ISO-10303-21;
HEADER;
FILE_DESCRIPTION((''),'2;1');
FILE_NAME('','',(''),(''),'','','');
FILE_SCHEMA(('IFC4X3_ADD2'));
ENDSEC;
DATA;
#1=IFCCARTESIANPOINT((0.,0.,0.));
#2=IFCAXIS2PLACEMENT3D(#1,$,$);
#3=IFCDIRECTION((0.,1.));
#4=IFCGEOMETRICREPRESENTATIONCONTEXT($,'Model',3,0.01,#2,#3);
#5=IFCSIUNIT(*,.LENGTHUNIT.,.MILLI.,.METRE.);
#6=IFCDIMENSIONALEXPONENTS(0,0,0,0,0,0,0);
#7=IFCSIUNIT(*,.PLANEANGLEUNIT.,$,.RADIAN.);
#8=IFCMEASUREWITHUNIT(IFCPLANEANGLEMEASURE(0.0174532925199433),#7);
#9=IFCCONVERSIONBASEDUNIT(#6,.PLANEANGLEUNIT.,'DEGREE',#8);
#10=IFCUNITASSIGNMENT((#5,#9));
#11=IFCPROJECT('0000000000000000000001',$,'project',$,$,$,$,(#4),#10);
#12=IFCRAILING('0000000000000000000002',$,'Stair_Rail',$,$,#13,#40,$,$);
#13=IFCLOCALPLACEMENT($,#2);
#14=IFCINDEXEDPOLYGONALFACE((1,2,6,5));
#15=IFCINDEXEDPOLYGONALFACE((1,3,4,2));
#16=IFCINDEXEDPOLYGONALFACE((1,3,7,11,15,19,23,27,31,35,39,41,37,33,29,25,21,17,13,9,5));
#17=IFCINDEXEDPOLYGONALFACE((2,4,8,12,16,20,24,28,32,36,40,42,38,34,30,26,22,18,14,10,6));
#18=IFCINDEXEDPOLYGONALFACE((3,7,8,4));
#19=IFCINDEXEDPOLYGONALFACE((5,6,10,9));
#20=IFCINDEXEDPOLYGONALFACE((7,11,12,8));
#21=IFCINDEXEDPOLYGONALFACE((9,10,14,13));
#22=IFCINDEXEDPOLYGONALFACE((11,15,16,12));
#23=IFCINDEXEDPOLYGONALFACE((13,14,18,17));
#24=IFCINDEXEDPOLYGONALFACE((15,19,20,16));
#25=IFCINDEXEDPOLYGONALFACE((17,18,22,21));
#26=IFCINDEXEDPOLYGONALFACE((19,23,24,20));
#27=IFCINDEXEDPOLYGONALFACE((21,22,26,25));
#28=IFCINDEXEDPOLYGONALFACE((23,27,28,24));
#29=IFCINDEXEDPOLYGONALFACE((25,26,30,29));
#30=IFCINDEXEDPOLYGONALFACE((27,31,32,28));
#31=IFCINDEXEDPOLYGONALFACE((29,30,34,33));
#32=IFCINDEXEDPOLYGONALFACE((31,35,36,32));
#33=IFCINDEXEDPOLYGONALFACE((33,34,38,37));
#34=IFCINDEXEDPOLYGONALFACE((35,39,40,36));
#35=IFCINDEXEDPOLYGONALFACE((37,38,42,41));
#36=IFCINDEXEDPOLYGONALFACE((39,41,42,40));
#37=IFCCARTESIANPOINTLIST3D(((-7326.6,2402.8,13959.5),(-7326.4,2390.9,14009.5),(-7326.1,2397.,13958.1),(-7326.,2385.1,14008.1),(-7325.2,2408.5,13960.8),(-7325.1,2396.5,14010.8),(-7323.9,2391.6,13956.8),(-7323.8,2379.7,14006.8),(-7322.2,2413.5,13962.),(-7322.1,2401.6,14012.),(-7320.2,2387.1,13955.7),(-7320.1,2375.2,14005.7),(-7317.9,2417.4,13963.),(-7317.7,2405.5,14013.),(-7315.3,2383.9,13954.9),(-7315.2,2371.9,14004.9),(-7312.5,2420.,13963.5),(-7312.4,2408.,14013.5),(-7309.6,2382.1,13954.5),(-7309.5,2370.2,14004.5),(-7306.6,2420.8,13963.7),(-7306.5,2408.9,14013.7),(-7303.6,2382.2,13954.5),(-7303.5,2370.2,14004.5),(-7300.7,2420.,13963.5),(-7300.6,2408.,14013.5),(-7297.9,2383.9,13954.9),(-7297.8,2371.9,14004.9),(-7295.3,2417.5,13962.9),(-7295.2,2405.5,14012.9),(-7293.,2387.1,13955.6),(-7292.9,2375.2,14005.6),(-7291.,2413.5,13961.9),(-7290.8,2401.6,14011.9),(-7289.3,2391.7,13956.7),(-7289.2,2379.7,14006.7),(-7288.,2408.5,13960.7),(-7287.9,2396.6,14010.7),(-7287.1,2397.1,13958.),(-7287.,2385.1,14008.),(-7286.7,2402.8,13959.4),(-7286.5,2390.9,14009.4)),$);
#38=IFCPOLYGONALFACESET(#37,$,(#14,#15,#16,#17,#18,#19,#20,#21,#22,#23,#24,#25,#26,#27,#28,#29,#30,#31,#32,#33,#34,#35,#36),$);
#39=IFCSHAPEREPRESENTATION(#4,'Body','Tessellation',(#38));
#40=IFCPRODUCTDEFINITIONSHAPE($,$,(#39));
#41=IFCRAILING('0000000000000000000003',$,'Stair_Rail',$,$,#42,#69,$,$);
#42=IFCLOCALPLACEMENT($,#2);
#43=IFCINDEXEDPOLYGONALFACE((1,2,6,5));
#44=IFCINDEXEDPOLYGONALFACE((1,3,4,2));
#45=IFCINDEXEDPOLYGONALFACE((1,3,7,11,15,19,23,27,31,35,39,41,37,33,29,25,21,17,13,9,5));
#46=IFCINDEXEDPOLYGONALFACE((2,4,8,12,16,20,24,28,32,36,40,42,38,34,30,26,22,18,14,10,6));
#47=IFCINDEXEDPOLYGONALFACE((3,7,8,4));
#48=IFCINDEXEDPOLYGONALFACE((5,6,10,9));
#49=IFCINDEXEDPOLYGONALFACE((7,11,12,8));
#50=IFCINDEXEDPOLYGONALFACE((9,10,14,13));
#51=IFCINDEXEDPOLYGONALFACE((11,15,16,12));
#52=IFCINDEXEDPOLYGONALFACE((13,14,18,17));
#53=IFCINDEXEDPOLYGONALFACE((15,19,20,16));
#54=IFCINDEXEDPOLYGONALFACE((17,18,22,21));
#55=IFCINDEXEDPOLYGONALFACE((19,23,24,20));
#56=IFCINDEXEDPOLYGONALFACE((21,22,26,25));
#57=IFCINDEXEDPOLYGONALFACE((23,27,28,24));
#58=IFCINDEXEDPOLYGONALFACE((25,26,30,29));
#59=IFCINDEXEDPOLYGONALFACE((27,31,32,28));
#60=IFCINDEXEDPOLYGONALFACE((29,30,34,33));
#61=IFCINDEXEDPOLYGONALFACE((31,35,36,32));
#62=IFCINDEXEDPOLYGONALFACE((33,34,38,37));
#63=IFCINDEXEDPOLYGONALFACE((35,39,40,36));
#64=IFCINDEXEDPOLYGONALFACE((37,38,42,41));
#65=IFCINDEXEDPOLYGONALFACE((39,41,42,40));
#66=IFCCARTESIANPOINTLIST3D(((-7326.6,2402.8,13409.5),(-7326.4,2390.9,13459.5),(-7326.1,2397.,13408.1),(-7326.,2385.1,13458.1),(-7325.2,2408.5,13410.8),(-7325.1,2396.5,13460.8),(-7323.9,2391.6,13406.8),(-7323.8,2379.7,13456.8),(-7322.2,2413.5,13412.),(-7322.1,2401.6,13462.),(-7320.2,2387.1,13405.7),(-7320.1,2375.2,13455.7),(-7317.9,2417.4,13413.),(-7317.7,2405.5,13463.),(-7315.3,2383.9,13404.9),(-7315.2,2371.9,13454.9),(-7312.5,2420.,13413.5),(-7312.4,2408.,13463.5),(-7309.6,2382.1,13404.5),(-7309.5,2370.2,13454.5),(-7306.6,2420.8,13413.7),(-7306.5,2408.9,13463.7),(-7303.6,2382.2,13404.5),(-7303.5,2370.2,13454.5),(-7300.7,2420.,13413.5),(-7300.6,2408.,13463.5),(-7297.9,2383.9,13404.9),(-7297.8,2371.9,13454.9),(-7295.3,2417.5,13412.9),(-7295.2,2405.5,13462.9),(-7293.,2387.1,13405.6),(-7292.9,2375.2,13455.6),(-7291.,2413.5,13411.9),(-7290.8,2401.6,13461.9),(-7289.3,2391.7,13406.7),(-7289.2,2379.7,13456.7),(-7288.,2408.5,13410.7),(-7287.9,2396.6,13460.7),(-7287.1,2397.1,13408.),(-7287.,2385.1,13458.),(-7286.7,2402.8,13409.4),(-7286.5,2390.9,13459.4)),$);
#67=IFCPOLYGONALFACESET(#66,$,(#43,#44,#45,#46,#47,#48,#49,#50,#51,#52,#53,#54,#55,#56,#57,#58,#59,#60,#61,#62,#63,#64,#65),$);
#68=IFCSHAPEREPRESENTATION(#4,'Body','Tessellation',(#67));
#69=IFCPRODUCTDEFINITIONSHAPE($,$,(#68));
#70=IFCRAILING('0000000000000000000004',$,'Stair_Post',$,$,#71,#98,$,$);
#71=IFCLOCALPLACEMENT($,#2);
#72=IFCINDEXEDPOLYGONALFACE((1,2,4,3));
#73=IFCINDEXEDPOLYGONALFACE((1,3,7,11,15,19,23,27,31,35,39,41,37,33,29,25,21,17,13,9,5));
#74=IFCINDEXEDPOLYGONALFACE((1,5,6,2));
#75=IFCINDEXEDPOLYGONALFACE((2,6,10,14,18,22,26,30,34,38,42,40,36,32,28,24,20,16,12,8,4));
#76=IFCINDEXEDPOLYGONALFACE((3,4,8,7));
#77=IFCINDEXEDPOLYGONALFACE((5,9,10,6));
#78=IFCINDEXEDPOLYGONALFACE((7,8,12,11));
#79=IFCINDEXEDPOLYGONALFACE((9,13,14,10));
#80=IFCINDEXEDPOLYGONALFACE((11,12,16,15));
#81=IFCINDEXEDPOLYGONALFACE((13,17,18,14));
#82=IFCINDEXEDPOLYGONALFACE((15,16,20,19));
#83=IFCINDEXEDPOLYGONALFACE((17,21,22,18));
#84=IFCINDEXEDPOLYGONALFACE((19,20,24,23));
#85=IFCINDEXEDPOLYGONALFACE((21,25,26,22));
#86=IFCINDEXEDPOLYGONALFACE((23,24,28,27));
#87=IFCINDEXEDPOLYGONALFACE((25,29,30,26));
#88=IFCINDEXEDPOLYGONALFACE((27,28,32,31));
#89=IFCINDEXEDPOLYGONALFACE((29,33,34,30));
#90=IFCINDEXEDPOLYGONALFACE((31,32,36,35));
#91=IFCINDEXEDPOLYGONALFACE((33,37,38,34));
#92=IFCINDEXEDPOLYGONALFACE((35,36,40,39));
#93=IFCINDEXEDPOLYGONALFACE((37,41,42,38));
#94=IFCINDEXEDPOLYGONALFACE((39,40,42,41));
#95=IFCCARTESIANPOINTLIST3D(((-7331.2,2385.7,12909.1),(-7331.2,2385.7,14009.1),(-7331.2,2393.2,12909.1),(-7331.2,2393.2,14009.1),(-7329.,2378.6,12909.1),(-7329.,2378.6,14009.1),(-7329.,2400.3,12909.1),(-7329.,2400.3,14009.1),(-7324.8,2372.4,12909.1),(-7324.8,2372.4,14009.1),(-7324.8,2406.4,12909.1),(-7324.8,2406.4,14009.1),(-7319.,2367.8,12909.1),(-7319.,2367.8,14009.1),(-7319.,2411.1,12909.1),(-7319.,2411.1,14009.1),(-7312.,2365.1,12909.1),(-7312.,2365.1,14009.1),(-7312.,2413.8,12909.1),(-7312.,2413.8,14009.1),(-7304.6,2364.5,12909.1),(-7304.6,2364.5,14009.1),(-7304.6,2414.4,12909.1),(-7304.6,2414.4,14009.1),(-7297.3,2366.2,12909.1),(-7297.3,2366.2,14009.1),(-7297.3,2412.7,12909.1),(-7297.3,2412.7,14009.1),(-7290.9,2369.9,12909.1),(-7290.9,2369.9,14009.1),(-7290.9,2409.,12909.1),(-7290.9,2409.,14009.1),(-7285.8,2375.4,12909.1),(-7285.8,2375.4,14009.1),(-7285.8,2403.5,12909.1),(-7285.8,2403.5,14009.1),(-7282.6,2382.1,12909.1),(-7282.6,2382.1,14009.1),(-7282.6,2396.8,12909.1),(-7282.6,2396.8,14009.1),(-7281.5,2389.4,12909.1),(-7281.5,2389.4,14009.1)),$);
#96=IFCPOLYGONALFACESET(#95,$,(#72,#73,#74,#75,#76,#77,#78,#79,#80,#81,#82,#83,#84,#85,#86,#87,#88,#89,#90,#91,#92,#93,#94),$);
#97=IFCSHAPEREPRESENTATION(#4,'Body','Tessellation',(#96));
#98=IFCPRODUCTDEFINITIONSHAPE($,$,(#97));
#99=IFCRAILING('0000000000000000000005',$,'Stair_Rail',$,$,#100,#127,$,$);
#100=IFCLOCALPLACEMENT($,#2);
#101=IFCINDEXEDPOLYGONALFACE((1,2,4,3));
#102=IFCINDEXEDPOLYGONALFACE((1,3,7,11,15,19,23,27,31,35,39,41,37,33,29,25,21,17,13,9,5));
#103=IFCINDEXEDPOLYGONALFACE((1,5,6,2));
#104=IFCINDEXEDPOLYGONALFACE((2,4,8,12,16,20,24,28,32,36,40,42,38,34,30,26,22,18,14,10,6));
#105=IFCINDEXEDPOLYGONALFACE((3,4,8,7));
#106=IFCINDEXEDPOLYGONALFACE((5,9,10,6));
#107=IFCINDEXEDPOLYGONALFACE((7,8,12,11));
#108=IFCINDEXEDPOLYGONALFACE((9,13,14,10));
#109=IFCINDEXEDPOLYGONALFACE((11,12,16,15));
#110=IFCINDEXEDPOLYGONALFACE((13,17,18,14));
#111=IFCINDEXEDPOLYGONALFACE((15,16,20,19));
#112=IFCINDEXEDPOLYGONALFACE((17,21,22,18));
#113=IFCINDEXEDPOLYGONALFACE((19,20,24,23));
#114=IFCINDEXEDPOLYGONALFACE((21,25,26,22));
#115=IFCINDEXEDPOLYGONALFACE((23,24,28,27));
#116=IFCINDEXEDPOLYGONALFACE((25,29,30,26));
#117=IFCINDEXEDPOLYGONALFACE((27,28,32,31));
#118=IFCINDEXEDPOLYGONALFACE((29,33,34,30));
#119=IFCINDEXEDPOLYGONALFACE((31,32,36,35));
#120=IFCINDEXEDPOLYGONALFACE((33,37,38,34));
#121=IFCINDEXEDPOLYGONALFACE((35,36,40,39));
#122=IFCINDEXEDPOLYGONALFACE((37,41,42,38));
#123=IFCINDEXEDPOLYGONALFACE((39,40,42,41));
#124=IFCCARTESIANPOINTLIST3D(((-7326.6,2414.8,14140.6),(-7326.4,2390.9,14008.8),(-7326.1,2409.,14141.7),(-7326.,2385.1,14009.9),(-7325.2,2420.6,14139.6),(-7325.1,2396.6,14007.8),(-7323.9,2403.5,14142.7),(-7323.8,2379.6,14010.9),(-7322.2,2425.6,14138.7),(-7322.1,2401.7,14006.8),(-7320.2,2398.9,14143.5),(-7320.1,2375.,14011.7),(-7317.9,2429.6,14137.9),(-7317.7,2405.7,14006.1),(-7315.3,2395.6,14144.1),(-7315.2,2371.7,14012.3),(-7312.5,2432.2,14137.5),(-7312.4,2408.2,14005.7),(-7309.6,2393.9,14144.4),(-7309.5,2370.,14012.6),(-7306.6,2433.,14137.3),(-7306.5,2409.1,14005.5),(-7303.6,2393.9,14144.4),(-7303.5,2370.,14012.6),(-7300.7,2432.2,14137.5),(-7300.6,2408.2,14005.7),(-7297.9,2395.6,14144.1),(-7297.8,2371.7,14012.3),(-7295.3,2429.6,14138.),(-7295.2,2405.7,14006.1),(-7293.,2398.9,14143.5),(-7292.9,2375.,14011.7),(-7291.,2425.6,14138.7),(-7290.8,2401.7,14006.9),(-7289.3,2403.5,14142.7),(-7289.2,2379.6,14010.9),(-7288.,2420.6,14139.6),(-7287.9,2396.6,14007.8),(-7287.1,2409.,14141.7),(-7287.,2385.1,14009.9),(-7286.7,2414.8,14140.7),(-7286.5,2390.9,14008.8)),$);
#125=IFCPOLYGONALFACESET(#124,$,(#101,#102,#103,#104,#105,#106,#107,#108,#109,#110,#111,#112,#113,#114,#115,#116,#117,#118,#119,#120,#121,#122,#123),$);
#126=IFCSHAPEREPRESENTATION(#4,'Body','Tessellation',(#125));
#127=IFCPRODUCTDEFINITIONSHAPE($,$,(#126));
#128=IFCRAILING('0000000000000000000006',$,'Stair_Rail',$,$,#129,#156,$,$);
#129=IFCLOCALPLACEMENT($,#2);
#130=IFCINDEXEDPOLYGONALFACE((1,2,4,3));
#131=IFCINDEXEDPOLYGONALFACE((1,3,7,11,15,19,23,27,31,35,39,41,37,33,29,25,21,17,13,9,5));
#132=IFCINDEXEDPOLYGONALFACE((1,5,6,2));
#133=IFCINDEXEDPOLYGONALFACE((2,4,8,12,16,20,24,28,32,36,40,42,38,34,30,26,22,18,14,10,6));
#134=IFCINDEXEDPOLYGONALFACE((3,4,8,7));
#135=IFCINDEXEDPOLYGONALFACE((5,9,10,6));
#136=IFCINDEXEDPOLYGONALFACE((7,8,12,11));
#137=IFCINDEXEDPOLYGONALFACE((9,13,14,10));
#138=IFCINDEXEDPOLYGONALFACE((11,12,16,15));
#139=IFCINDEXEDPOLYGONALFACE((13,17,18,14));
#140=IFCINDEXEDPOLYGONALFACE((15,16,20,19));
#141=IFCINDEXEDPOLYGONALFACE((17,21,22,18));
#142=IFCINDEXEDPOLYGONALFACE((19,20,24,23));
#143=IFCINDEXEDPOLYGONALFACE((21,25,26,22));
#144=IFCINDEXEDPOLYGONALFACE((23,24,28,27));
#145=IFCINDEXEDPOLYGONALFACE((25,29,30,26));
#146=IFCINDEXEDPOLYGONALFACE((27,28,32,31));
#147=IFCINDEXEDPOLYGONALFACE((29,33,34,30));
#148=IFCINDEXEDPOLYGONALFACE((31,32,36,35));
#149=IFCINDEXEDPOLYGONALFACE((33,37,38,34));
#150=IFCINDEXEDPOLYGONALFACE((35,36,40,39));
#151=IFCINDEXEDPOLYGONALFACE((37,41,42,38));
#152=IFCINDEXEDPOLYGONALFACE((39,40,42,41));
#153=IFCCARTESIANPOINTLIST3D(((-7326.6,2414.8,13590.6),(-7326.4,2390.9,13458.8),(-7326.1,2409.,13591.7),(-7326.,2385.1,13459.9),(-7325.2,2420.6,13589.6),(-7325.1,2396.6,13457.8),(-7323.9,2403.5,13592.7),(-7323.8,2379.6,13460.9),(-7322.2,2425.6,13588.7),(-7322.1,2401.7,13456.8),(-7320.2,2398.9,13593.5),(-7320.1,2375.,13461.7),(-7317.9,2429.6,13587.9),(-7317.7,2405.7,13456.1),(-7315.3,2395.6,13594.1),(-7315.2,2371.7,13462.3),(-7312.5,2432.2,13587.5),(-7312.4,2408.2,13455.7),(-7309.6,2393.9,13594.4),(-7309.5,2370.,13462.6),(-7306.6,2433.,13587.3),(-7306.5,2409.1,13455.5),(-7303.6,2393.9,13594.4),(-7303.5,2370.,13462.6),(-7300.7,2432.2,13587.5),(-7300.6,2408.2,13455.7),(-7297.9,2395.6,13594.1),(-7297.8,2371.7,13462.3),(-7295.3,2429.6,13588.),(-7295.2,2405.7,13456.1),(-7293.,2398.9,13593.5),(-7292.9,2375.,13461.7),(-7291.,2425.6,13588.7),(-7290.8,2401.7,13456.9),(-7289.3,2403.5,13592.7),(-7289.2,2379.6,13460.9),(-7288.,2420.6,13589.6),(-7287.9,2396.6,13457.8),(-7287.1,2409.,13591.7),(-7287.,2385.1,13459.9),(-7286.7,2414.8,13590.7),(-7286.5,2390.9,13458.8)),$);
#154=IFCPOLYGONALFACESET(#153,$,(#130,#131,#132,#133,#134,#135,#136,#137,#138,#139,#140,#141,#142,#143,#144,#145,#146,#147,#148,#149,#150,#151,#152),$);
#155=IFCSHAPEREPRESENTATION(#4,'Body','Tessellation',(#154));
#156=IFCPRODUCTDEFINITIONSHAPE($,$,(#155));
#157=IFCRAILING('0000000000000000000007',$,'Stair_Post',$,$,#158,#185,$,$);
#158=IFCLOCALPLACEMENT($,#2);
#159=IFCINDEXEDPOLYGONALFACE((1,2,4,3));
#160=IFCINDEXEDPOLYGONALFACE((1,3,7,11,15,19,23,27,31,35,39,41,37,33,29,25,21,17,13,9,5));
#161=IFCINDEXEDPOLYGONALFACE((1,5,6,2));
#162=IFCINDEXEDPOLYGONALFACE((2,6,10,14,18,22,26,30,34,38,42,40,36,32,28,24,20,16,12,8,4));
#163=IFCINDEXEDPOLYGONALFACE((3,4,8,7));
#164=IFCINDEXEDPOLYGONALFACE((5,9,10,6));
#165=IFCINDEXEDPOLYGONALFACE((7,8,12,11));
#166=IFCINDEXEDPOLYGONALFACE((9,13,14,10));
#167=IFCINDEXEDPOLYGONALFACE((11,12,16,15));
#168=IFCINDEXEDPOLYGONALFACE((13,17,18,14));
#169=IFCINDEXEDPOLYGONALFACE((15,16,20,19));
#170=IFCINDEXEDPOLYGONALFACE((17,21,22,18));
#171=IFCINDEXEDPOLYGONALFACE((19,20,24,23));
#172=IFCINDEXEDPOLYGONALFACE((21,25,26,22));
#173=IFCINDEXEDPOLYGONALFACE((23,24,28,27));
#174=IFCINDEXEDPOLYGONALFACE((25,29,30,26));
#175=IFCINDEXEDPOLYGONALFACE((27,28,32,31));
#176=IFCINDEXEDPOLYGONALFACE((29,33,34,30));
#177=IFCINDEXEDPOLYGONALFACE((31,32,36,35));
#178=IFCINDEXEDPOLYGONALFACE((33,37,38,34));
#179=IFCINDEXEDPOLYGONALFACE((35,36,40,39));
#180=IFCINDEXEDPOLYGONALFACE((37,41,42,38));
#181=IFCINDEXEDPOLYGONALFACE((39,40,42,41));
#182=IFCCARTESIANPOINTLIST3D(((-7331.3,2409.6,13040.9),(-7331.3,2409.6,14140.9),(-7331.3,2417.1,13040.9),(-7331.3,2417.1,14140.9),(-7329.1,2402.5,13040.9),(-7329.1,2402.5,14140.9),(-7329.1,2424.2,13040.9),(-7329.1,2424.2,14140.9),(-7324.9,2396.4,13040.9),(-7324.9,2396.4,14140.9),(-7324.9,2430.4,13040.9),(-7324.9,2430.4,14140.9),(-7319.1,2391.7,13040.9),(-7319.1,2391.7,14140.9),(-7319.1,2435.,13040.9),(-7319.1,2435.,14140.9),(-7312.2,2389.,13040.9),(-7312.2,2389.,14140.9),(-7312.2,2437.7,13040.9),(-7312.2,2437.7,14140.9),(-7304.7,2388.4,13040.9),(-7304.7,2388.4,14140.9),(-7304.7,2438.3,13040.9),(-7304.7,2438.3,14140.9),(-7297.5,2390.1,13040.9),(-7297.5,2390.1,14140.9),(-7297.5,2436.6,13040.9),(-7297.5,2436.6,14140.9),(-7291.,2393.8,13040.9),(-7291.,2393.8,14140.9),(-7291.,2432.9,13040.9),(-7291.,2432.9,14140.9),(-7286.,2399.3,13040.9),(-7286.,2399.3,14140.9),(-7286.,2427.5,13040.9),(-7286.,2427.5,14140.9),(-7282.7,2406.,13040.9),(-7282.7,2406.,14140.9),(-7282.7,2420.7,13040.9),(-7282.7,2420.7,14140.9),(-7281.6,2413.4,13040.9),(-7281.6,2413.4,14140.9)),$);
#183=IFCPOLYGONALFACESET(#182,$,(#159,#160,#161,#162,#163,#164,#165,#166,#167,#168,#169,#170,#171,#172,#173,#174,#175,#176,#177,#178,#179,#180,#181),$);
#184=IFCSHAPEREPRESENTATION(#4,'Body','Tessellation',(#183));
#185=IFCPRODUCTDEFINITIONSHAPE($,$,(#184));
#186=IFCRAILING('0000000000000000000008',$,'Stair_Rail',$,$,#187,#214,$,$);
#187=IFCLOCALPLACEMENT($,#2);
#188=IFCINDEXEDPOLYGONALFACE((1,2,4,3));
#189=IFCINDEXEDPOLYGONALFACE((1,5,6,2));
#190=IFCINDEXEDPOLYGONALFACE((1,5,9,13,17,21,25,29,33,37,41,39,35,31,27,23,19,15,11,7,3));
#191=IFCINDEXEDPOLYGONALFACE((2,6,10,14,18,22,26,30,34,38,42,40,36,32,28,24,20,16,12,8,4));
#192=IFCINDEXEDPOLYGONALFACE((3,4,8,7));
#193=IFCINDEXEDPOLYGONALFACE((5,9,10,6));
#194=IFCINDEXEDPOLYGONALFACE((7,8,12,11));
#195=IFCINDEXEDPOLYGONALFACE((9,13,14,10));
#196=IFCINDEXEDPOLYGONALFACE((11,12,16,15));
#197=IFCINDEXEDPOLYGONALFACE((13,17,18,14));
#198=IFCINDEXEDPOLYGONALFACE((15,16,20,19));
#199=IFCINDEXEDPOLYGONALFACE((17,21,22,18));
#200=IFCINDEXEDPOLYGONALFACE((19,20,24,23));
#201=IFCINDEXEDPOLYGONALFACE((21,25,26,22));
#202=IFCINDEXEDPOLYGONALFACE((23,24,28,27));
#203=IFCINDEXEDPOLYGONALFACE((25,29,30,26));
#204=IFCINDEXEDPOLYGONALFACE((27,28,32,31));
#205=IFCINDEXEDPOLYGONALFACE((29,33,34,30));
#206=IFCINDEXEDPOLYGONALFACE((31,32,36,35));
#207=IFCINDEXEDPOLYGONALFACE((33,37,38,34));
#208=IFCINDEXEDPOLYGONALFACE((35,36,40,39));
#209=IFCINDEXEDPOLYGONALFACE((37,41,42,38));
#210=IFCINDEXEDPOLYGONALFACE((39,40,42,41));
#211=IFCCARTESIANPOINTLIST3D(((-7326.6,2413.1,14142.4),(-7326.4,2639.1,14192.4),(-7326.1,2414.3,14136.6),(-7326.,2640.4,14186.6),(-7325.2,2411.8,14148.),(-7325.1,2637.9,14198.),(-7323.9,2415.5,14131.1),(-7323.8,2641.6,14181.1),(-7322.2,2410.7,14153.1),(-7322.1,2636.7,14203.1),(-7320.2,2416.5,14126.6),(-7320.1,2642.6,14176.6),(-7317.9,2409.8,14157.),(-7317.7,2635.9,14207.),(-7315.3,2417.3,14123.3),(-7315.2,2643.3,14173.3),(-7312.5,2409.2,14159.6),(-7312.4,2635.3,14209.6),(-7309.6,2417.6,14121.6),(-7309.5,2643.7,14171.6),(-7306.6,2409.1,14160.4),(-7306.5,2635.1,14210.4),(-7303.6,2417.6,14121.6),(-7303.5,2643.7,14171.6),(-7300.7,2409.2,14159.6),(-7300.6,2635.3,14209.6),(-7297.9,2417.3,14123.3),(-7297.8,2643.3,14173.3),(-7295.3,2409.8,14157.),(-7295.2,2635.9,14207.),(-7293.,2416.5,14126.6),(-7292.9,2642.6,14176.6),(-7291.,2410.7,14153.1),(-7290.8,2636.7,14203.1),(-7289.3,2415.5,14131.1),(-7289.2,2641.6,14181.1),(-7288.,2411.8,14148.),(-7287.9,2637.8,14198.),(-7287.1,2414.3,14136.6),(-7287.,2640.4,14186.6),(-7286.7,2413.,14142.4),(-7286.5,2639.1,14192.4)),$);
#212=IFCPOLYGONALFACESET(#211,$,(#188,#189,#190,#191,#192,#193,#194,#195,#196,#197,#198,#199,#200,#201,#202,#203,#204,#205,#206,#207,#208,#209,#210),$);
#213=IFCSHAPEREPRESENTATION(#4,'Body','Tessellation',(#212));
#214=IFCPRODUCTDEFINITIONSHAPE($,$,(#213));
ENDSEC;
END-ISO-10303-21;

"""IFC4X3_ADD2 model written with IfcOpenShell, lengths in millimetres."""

from ifc_helpers import new_model, entity, si_unit, converted_unit, direction, frame, origin, context, project, circle, extrude, element, save


model = new_model("IFC4X3_ADD2")

# Units and contexts
model_context = context("Model", 3, precision=0.01, world=origin(), true_north=direction((0.0, 1.0)))
ifc_project = project(units=[si_unit("LENGTHUNIT", "METRE", prefix="MILLI"), converted_unit("PLANEANGLEUNIT", "DEGREE", entity("IfcPlaneAngleMeasure", 0.0174532925199433), si_unit("PLANEANGLEUNIT", "RADIAN"), dimensions=[0, 0, 0, 0, 0, 0, 0])], contexts=[model_context])

# Railings
element("IfcRailing", 1, Name="Stair_Rail", context=model_context, shape_type="SweptSolid", body=[
    entity("IfcSweptDiskSolid", entity("IfcPolyline", [entity("IfcCartesianPoint", [-7306.6, 2401.4, 13959.1]), entity("IfcCartesianPoint", [-7306.5, 2389.4, 14009.1])]), 20.0),
])
element("IfcRailing", 2, Name="Stair_Rail", context=model_context, shape_type="SweptSolid", body=[
    entity("IfcSweptDiskSolid", entity("IfcPolyline", [entity("IfcCartesianPoint", [-7306.6, 2401.4, 13409.1]), entity("IfcCartesianPoint", [-7306.5, 2389.4, 13459.1])]), 20.0),
])
element("IfcRailing", 3, Name="Stair_Post", context=model_context, shape_type="SweptSolid", body=[
    extrude(circle(Radius=25.0), frame((-7306.5, 2389.4, 12909.1)), (0.0, 0.0, 1.0), 1100.0),
])
element("IfcRailing", 4, Name="Stair_Rail", context=model_context, shape_type="SweptSolid", body=[
    entity("IfcSweptDiskSolid", entity("IfcPolyline", [entity("IfcCartesianPoint", [-7306.5, 2389.4, 14009.1]), entity("IfcCartesianPoint", [-7306.6, 2413.4, 14140.9])]), 20.0),
])
element("IfcRailing", 5, Name="Stair_Rail", context=model_context, shape_type="SweptSolid", body=[
    entity("IfcSweptDiskSolid", entity("IfcPolyline", [entity("IfcCartesianPoint", [-7306.5, 2389.4, 13459.1]), entity("IfcCartesianPoint", [-7306.6, 2413.4, 13590.9])]), 20.0),
])
element("IfcRailing", 6, Name="Stair_Post", context=model_context, shape_type="SweptSolid", body=[
    extrude(circle(Radius=25.0), frame((-7306.6, 2413.4, 13040.9)), (0.0, 0.0, 1.0), 1100.0),
])
element("IfcRailing", 7, Name="Stair_Rail", context=model_context, shape_type="SweptSolid", body=[
    entity("IfcSweptDiskSolid", entity("IfcPolyline", [entity("IfcCartesianPoint", [-7306.6, 2413.4, 14140.9]), entity("IfcCartesianPoint", [-7306.5, 2639.4, 14190.9])]), 20.0),
])

save(model, "model.ifc")
